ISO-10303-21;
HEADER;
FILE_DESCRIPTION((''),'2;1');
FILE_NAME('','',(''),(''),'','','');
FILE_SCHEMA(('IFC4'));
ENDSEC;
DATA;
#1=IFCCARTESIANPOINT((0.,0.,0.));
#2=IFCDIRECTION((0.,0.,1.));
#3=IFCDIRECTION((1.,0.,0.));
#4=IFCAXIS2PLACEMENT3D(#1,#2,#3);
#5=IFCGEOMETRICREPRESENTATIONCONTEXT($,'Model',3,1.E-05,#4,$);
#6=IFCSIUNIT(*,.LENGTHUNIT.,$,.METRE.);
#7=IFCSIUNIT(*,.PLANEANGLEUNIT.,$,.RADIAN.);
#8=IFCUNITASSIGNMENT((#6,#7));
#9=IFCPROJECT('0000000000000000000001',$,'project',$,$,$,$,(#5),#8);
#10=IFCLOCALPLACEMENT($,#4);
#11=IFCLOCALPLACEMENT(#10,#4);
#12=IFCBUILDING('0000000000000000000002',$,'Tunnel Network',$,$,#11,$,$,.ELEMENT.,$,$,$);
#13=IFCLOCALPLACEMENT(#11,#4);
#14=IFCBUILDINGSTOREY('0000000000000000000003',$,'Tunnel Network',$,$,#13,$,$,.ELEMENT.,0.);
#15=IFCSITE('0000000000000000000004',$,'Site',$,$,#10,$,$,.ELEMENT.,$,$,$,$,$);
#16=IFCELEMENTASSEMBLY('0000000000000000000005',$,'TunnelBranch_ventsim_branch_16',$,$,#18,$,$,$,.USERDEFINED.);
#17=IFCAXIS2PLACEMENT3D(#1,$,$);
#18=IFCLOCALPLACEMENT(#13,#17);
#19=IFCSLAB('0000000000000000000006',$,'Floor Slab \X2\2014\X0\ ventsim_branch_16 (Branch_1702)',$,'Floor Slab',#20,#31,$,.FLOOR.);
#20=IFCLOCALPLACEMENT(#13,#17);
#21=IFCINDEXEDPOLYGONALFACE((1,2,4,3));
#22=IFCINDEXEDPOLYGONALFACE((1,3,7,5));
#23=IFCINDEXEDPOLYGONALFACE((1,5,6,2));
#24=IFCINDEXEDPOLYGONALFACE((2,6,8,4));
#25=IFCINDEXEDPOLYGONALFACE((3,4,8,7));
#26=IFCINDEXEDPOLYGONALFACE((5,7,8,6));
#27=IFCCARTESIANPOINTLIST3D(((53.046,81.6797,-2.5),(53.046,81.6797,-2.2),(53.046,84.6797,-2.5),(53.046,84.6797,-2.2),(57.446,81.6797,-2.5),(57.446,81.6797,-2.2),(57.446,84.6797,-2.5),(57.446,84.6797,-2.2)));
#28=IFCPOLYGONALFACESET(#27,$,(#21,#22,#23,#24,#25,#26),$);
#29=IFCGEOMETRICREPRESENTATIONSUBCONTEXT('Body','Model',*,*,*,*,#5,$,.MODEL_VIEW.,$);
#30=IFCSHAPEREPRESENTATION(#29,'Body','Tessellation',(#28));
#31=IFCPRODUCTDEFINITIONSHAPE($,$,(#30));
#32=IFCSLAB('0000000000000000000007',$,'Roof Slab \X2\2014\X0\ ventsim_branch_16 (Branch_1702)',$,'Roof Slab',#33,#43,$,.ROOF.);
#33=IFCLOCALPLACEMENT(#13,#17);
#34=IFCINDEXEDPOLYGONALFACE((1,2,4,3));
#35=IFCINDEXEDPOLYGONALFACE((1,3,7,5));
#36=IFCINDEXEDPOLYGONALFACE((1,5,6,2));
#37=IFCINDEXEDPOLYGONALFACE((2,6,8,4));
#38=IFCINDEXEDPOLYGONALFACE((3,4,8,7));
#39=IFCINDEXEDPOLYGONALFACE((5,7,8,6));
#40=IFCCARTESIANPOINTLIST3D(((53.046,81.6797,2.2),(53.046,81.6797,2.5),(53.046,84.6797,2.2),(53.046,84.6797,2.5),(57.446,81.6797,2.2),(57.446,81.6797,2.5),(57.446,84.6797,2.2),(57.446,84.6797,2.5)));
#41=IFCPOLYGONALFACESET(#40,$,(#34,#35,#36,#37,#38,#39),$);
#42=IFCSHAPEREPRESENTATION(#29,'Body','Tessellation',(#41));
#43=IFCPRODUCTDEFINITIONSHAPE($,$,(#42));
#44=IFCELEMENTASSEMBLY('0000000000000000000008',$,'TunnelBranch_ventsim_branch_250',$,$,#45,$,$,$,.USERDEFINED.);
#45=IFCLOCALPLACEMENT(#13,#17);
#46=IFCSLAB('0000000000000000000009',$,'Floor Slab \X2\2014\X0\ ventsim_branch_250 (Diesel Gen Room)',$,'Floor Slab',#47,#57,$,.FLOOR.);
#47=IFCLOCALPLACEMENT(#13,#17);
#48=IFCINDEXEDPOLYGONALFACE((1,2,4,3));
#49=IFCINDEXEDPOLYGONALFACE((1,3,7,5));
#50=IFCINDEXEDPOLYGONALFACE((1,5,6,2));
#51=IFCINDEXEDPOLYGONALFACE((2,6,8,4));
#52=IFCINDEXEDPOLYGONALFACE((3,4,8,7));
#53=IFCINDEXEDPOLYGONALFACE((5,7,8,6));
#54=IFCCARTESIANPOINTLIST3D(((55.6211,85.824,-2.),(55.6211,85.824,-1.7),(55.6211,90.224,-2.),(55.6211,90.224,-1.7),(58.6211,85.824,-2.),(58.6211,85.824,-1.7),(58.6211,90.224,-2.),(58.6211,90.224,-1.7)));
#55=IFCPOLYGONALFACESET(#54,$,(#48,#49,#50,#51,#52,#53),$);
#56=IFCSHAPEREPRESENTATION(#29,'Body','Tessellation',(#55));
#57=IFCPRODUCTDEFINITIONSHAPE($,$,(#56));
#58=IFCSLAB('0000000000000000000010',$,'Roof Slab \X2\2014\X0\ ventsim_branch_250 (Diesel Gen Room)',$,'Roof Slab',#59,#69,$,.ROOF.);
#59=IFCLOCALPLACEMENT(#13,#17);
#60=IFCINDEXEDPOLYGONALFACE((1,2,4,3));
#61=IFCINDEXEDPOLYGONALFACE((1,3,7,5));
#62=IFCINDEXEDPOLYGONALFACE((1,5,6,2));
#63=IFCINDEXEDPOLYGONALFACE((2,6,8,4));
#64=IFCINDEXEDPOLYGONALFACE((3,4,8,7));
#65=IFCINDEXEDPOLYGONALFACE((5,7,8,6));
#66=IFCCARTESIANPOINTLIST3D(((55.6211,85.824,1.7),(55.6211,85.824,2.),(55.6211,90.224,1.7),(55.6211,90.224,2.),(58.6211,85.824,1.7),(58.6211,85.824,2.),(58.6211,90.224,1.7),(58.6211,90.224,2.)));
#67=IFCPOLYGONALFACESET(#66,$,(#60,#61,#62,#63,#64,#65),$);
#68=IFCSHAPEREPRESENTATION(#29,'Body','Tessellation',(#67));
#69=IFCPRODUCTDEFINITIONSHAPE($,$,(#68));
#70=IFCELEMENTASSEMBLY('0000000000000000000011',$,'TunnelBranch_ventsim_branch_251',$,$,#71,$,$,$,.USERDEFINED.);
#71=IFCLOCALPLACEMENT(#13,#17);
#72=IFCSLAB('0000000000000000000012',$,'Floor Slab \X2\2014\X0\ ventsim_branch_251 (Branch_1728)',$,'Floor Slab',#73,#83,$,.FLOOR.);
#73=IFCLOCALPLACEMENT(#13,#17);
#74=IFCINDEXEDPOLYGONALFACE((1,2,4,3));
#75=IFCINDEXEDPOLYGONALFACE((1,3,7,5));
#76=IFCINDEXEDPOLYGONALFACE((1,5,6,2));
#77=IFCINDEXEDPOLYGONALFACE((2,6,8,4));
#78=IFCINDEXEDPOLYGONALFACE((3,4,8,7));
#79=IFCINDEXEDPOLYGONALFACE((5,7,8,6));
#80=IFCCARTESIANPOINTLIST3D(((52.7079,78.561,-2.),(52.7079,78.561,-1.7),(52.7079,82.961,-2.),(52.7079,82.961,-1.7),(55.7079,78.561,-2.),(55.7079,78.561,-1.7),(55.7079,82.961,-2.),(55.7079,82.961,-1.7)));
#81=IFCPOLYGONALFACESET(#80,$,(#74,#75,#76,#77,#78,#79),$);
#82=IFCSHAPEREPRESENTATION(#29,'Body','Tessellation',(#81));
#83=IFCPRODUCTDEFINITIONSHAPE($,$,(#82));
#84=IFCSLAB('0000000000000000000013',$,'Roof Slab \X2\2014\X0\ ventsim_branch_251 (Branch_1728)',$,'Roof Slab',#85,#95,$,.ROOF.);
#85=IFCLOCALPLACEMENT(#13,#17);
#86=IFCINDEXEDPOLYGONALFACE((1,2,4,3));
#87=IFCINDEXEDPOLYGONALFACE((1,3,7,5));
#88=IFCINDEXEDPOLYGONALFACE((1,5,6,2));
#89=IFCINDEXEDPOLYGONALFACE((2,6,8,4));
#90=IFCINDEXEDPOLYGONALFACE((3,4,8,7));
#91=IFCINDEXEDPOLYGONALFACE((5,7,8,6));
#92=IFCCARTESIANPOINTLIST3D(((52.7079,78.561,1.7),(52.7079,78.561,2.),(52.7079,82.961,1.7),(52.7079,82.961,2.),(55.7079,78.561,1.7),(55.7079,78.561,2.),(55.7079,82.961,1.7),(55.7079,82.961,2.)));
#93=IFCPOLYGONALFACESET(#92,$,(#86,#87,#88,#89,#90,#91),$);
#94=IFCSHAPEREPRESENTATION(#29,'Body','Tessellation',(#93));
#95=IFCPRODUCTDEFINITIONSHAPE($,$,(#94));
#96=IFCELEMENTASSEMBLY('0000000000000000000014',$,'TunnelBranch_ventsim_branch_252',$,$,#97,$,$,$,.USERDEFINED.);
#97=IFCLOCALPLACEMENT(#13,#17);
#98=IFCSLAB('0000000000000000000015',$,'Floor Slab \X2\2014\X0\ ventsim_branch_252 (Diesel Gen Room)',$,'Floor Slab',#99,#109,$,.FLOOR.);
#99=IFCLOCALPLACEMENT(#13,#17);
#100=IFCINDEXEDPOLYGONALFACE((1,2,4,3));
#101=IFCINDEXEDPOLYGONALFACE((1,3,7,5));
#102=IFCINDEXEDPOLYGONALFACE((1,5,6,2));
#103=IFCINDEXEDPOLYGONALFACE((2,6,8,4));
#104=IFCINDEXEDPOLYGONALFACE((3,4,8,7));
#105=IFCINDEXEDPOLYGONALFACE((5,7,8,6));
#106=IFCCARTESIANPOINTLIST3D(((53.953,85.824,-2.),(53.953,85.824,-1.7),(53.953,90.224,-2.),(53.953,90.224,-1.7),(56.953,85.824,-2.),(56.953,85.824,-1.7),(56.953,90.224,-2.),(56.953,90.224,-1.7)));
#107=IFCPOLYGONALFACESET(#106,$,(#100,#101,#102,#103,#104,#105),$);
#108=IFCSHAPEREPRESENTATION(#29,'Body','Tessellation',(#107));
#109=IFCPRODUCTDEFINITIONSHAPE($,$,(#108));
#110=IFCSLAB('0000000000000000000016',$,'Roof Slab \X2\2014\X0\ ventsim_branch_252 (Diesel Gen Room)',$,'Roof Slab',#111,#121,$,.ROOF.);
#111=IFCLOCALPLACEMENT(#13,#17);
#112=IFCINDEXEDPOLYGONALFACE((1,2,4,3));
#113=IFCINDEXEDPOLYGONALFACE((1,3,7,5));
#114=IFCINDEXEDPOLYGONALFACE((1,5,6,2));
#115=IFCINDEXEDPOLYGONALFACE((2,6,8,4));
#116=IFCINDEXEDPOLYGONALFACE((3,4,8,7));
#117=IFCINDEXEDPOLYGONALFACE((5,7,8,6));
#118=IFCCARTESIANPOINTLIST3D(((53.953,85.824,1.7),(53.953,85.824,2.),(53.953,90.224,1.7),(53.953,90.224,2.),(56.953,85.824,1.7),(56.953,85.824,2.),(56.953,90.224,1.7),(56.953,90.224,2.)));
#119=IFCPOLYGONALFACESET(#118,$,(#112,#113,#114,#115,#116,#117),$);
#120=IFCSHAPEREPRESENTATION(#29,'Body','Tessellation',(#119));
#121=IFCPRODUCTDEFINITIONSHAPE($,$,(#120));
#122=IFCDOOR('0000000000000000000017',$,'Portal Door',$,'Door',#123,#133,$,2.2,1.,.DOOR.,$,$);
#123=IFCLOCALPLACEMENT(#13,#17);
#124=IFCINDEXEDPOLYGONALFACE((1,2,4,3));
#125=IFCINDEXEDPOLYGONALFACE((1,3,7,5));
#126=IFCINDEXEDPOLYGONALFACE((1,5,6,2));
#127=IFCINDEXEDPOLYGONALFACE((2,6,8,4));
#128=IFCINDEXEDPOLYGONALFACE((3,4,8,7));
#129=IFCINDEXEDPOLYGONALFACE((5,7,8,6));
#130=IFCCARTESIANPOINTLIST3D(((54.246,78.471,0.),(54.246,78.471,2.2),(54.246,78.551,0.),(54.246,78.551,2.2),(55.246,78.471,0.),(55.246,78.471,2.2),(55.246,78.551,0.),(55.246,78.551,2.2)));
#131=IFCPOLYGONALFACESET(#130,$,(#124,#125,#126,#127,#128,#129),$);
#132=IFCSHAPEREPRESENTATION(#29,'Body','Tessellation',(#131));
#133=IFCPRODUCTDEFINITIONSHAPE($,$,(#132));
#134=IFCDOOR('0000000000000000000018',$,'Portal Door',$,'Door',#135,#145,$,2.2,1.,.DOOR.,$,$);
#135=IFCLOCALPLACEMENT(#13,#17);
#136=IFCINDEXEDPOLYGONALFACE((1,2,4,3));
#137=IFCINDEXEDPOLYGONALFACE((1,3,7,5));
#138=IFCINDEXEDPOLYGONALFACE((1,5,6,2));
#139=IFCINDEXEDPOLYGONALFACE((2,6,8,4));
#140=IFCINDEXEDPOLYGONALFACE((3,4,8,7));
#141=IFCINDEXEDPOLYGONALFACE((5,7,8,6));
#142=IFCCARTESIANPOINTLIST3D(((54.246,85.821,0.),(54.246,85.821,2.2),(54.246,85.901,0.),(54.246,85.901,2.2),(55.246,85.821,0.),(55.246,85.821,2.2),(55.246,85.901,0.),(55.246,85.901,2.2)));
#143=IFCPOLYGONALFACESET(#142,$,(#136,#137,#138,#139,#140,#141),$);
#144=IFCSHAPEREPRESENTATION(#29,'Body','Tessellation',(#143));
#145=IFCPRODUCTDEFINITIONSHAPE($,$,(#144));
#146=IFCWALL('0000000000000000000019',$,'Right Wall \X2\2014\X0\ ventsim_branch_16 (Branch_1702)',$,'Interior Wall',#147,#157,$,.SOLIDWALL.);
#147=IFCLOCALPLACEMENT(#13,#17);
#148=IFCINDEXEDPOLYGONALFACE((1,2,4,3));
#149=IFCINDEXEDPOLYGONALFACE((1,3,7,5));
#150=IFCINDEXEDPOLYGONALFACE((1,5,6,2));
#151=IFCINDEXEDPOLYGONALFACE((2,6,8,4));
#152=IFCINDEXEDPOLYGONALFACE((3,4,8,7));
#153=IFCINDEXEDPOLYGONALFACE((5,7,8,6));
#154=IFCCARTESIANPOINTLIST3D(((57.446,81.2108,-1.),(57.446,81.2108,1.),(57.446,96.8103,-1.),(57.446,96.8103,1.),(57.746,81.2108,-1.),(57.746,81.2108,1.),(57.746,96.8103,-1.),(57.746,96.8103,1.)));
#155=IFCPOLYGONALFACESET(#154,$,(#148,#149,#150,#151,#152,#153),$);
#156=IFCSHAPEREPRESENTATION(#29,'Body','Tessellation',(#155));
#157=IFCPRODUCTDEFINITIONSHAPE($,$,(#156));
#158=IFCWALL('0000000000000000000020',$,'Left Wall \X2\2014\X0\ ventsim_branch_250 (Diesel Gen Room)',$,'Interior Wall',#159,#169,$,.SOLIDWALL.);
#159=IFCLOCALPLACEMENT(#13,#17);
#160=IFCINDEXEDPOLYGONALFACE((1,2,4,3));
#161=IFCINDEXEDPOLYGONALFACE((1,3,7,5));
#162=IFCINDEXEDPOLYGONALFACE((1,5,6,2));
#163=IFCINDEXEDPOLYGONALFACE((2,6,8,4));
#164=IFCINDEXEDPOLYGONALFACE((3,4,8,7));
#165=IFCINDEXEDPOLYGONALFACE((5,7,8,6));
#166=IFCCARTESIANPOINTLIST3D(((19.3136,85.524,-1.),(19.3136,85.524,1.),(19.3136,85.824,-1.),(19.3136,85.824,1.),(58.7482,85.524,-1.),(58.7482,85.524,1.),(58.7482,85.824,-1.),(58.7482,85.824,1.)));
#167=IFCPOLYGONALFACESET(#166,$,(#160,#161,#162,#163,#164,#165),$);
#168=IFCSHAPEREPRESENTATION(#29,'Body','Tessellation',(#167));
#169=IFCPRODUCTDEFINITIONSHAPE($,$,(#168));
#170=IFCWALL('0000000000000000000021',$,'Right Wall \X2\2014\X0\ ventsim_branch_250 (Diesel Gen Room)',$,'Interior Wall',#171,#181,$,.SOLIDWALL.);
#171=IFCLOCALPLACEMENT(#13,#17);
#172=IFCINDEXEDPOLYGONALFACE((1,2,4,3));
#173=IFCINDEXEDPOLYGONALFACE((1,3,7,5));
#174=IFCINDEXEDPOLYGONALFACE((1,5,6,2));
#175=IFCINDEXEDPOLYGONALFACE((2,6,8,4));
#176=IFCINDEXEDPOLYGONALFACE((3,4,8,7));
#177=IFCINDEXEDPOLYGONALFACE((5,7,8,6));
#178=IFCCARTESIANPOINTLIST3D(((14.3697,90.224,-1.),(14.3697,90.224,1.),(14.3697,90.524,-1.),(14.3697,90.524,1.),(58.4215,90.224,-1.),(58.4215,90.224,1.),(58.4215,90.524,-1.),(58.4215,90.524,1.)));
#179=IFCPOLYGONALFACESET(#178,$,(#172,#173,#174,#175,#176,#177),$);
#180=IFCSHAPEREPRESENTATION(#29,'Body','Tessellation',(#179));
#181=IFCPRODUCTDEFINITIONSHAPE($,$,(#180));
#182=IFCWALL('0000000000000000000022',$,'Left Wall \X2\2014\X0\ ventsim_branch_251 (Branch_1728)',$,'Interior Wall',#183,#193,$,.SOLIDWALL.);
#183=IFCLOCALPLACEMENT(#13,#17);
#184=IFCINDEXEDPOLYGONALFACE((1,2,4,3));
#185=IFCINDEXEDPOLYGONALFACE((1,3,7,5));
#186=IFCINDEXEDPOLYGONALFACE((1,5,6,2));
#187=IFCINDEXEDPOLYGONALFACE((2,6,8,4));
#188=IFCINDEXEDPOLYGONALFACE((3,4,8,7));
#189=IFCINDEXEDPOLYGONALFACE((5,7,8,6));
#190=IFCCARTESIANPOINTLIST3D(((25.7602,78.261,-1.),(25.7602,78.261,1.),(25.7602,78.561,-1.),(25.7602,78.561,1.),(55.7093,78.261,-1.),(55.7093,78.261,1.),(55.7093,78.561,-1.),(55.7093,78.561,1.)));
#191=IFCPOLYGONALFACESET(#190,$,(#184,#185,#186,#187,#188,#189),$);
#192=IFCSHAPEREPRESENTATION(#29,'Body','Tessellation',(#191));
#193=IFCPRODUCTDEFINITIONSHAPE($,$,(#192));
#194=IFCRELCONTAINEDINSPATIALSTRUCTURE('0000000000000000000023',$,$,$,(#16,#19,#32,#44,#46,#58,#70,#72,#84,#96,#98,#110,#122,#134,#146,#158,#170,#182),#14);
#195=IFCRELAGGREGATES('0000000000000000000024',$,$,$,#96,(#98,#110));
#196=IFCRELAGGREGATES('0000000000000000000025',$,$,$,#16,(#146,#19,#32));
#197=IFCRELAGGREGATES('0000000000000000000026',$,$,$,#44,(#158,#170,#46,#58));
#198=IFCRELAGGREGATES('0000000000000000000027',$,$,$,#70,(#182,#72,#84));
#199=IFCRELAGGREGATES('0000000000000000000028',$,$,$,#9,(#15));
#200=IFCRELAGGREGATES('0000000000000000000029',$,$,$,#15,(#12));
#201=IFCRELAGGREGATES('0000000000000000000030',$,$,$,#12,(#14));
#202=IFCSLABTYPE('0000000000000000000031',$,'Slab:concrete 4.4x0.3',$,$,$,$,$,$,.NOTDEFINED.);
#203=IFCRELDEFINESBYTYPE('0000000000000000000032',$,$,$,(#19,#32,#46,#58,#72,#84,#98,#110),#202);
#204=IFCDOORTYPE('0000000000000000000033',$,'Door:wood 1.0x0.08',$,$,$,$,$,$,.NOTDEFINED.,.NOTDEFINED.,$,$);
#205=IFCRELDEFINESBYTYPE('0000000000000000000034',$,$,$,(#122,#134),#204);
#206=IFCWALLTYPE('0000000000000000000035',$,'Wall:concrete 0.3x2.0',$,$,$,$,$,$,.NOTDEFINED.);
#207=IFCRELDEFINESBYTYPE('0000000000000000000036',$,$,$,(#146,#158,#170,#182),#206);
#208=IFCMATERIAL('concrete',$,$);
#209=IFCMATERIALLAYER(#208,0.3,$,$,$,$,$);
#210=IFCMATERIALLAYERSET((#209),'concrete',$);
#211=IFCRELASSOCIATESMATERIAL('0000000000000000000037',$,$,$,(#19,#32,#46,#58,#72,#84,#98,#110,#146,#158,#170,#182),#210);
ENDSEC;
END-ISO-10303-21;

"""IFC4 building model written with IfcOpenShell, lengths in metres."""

from ifc_helpers import new_model, si_unit, frame, origin_with_axes, origin_2d_with_axis, place, context, subcontext, project, spatial, rectangle, extrude, material, layer, layer_set, layer_usage, type_object, element, aggregate, save


model = new_model("IFC4")

# Units and contexts
model_context = context("Model", 3, precision=1e-05, world=origin_with_axes())
body_context = subcontext(model_context, "Body", "Model", "MODEL_VIEW")
ifc_project = project(units=[si_unit("LENGTHUNIT", "METRE"), si_unit("PLANEANGLEUNIT", "RADIAN")], contexts=[model_context])

# Site, building, storey
site_placement = place(None, origin_with_axes())
site = spatial("IfcSite", under=ifc_project, at=site_placement, Name="Site", CompositionType="ELEMENT")
building_placement = place(site_placement, origin_with_axes())
building = spatial("IfcBuilding", under=site, at=building_placement, Name="Tunnel Network", CompositionType="ELEMENT")
storey_placement = place(building_placement, origin_with_axes())
storey = spatial("IfcBuildingStorey", under=building, at=storey_placement, Name="Tunnel Network", CompositionType="ELEMENT", Elevation=0.0)

# Element assemblies, slabs
assembly_1_placement = place(storey_placement, frame((52.896, 81.6797, 0.0), z_axis=(0.0, 1.0, 0.0), x_axis=(1.0, 0.0, 0.0)))
assembly_1 = element("IfcElementAssembly", 1, at=assembly_1_placement, inside=storey, Name="TunnelBranch_ventsim_branch_16", PredefinedType="USERDEFINED")
ifc_material = material(Name="concrete")
ifc_layer = layer(ifc_material, 0.3)
ifc_layer_set = layer_set([ifc_layer], Name="concrete")
ifc_layer_usage_1 = layer_usage(ifc_layer_set, "AXIS3", "POSITIVE", 0.0)
slab_type = type_object("IfcSlabType", Name="Slab:concrete 4.4x0.3")
slab_1_placement = place(storey_placement, frame((55.246, 81.6797, -2.35), z_axis=(0.0, 1.0, 0.0), x_axis=(1.0, 0.0, 0.0)))
slab_1 = element("IfcSlab", 2, at=slab_1_placement, inside=storey, type_object=slab_type, material=ifc_layer_usage_1, Name="Floor Slab — ventsim_branch_16 (Branch_1702)", ObjectType="Floor Slab", PredefinedType="FLOOR", context=body_context, shape_type="SweptSolid", body=[
    extrude(rectangle(XDim=4.4, YDim=0.3, at=origin_2d_with_axis()), origin_with_axes(), (0.0, 0.0, 1.0), 3.0),
])
ifc_layer_usage_2 = layer_usage(ifc_layer_set, "AXIS3", "POSITIVE", 0.0)
slab_2_placement = place(storey_placement, frame((55.246, 81.6797, 2.35), z_axis=(0.0, 1.0, 0.0), x_axis=(1.0, 0.0, 0.0)))
slab_2 = element("IfcSlab", 3, at=slab_2_placement, inside=storey, type_object=slab_type, material=ifc_layer_usage_2, Name="Roof Slab — ventsim_branch_16 (Branch_1702)", ObjectType="Roof Slab", PredefinedType="ROOF", context=body_context, shape_type="SweptSolid", body=[
    extrude(rectangle(XDim=4.4, YDim=0.3, at=origin_2d_with_axis()), origin_with_axes(), (0.0, 0.0, 1.0), 3.0),
])
assembly_2_placement = place(storey_placement, frame((58.7482, 85.674, 0.0), z_axis=(-1.0, 0.0, 0.0), x_axis=(0.0, 1.0, 0.0)))
assembly_2 = element("IfcElementAssembly", 4, at=assembly_2_placement, inside=storey, Name="TunnelBranch_ventsim_branch_250", PredefinedType="USERDEFINED")
ifc_layer_usage_3 = layer_usage(ifc_layer_set, "AXIS3", "POSITIVE", 0.0)
slab_3_placement = place(storey_placement, frame((58.6211, 88.024, -1.85), z_axis=(-1.0, 0.0, 0.0), x_axis=(0.0, 1.0, 0.0)))
slab_3 = element("IfcSlab", 5, at=slab_3_placement, inside=storey, type_object=slab_type, material=ifc_layer_usage_3, Name="Floor Slab — ventsim_branch_250 (Diesel Gen Room)", ObjectType="Floor Slab", PredefinedType="FLOOR", context=body_context, shape_type="SweptSolid", body=[
    extrude(rectangle(XDim=4.4, YDim=0.3, at=origin_2d_with_axis()), origin_with_axes(), (0.0, 0.0, 1.0), 3.0),
])
ifc_layer_usage_4 = layer_usage(ifc_layer_set, "AXIS3", "POSITIVE", 0.0)
slab_4_placement = place(storey_placement, frame((58.6211, 88.024, 1.85), z_axis=(-1.0, 0.0, 0.0), x_axis=(0.0, 1.0, 0.0)))
slab_4 = element("IfcSlab", 6, at=slab_4_placement, inside=storey, type_object=slab_type, material=ifc_layer_usage_4, Name="Roof Slab — ventsim_branch_250 (Diesel Gen Room)", ObjectType="Roof Slab", PredefinedType="ROOF", context=body_context, shape_type="SweptSolid", body=[
    extrude(rectangle(XDim=4.4, YDim=0.3, at=origin_2d_with_axis()), origin_with_axes(), (0.0, 0.0, 1.0), 3.0),
])
assembly_3_placement = place(storey_placement, frame((55.7093, 78.411, 0.0), z_axis=(-1.0, 0.0, 0.0), x_axis=(0.0, 1.0, 0.0)))
assembly_3 = element("IfcElementAssembly", 7, at=assembly_3_placement, inside=storey, Name="TunnelBranch_ventsim_branch_251", PredefinedType="USERDEFINED")
ifc_layer_usage_5 = layer_usage(ifc_layer_set, "AXIS3", "POSITIVE", 0.0)
slab_5_placement = place(storey_placement, frame((55.7079, 80.761, -1.85), z_axis=(-1.0, 0.0, 0.0), x_axis=(0.0, 1.0, 0.0)))
slab_5 = element("IfcSlab", 8, at=slab_5_placement, inside=storey, type_object=slab_type, material=ifc_layer_usage_5, Name="Floor Slab — ventsim_branch_251 (Branch_1728)", ObjectType="Floor Slab", PredefinedType="FLOOR", context=body_context, shape_type="SweptSolid", body=[
    extrude(rectangle(XDim=4.4, YDim=0.3, at=origin_2d_with_axis()), origin_with_axes(), (0.0, 0.0, 1.0), 3.0),
])
ifc_layer_usage_6 = layer_usage(ifc_layer_set, "AXIS3", "POSITIVE", 0.0)
slab_6_placement = place(storey_placement, frame((55.7079, 80.761, 1.85), z_axis=(-1.0, 0.0, 0.0), x_axis=(0.0, 1.0, 0.0)))
slab_6 = element("IfcSlab", 9, at=slab_6_placement, inside=storey, type_object=slab_type, material=ifc_layer_usage_6, Name="Roof Slab — ventsim_branch_251 (Branch_1728)", ObjectType="Roof Slab", PredefinedType="ROOF", context=body_context, shape_type="SweptSolid", body=[
    extrude(rectangle(XDim=4.4, YDim=0.3, at=origin_2d_with_axis()), origin_with_axes(), (0.0, 0.0, 1.0), 3.0),
])
assembly_4_placement = place(storey_placement, frame((53.953, 90.374, 0.0), z_axis=(1.0, 0.0, 0.0), x_axis=(0.0, -1.0, 0.0)))
assembly_4 = element("IfcElementAssembly", 10, at=assembly_4_placement, inside=storey, Name="TunnelBranch_ventsim_branch_252", PredefinedType="USERDEFINED")
ifc_layer_usage_7 = layer_usage(ifc_layer_set, "AXIS3", "POSITIVE", 0.0)
slab_7_placement = place(storey_placement, frame((53.953, 88.024, -1.85), z_axis=(1.0, 0.0, 0.0), x_axis=(0.0, -1.0, 0.0)))
slab_7 = element("IfcSlab", 11, at=slab_7_placement, inside=storey, type_object=slab_type, material=ifc_layer_usage_7, Name="Floor Slab — ventsim_branch_252 (Diesel Gen Room)", ObjectType="Floor Slab", PredefinedType="FLOOR", context=body_context, shape_type="SweptSolid", body=[
    extrude(rectangle(XDim=4.4, YDim=0.3, at=origin_2d_with_axis()), origin_with_axes(), (0.0, 0.0, 1.0), 3.0),
])
ifc_layer_usage_8 = layer_usage(ifc_layer_set, "AXIS3", "POSITIVE", 0.0)
slab_8_placement = place(storey_placement, frame((53.953, 88.024, 1.85), z_axis=(1.0, 0.0, 0.0), x_axis=(0.0, -1.0, 0.0)))
slab_8 = element("IfcSlab", 12, at=slab_8_placement, inside=storey, type_object=slab_type, material=ifc_layer_usage_8, Name="Roof Slab — ventsim_branch_252 (Diesel Gen Room)", ObjectType="Roof Slab", PredefinedType="ROOF", context=body_context, shape_type="SweptSolid", body=[
    extrude(rectangle(XDim=4.4, YDim=0.3, at=origin_2d_with_axis()), origin_with_axes(), (0.0, 0.0, 1.0), 3.0),
])
aggregate(assembly_4, [slab_7, slab_8])

# Doors
door_type = type_object("IfcDoorType", Name="Door:wood 1.0x0.08")
for number, where, z_axis, x_axis, name in (
    (13, (54.746, 78.511, 0.0), (0.0, 0.0, 1.0), (1.0, 0.0, 0.0), "Portal Door"),
    (14, (54.746, 85.861, 0.0), (0.0, 0.0, 1.0), (1.0, 0.0, 0.0), "Portal Door"),
):
    element("IfcDoor", number, at=place(storey_placement, frame(where, z_axis=z_axis, x_axis=x_axis)), inside=storey, type_object=door_type, Name=name, ObjectType="Door", OverallHeight=2.2, OverallWidth=1.0, PredefinedType="DOOR", context=body_context, shape_type="SweptSolid", body=[
        extrude(rectangle(XDim=1.0, YDim=0.08, at=origin_2d_with_axis()), origin_with_axes(), (0.0, 0.0, 1.0), 2.2),
    ])

# Walls
ifc_layer_usage_9 = layer_usage(ifc_layer_set, "AXIS2", "POSITIVE", 0.0)
wall_type = type_object("IfcWallType", Name="Wall:concrete 0.3x2.0")
wall_1_placement = place(storey_placement, frame((57.596, 81.2108, 0.0), z_axis=(0.0, 1.0, 0.0), x_axis=(1.0, 0.0, 0.0)))
wall_1 = element("IfcWall", 15, at=wall_1_placement, inside=storey, type_object=wall_type, material=ifc_layer_usage_9, Name="Right Wall — ventsim_branch_16 (Branch_1702)", ObjectType="Interior Wall", PredefinedType="SOLIDWALL", context=body_context, shape_type="SweptSolid", body=[
    extrude(rectangle(XDim=0.3, YDim=2.0, at=origin_2d_with_axis()), origin_with_axes(), (0.0, 0.0, 1.0), 15.5996),
])
aggregate(assembly_1, [wall_1, slab_1, slab_2])
ifc_layer_usage_10 = layer_usage(ifc_layer_set, "AXIS2", "POSITIVE", 0.0)
wall_2_placement = place(storey_placement, frame((58.7482, 85.674, 0.0), z_axis=(-1.0, 0.0, 0.0), x_axis=(0.0, 1.0, 0.0)))
wall_2 = element("IfcWall", 16, at=wall_2_placement, inside=storey, type_object=wall_type, material=ifc_layer_usage_10, Name="Left Wall — ventsim_branch_250 (Diesel Gen Room)", ObjectType="Interior Wall", PredefinedType="SOLIDWALL", context=body_context, shape_type="SweptSolid", body=[
    extrude(rectangle(XDim=0.3, YDim=2.0, at=origin_2d_with_axis()), origin_with_axes(), (0.0, 0.0, 1.0), 39.4346),
])
ifc_layer_usage_11 = layer_usage(ifc_layer_set, "AXIS2", "POSITIVE", 0.0)
wall_3_placement = place(storey_placement, frame((58.4215, 90.374, 0.0), z_axis=(-1.0, 0.0, 0.0), x_axis=(0.0, 1.0, 0.0)))
wall_3 = element("IfcWall", 17, at=wall_3_placement, inside=storey, type_object=wall_type, material=ifc_layer_usage_11, Name="Right Wall — ventsim_branch_250 (Diesel Gen Room)", ObjectType="Interior Wall", PredefinedType="SOLIDWALL", context=body_context, shape_type="SweptSolid", body=[
    extrude(rectangle(XDim=0.3, YDim=2.0, at=origin_2d_with_axis()), origin_with_axes(), (0.0, 0.0, 1.0), 44.0518),
])
aggregate(assembly_2, [wall_2, wall_3, slab_3, slab_4])
ifc_layer_usage_12 = layer_usage(ifc_layer_set, "AXIS2", "POSITIVE", 0.0)
wall_4_placement = place(storey_placement, frame((55.7093, 78.411, 0.0), z_axis=(-1.0, 0.0, 0.0), x_axis=(0.0, 1.0, 0.0)))
wall_4 = element("IfcWall", 18, at=wall_4_placement, inside=storey, type_object=wall_type, material=ifc_layer_usage_12, Name="Left Wall — ventsim_branch_251 (Branch_1728)", ObjectType="Interior Wall", PredefinedType="SOLIDWALL", context=body_context, shape_type="SweptSolid", body=[
    extrude(rectangle(XDim=0.3, YDim=2.0, at=origin_2d_with_axis()), origin_with_axes(), (0.0, 0.0, 1.0), 29.9491),
])
aggregate(assembly_3, [wall_4, slab_5, slab_6])

save(model, "model.ifc")
